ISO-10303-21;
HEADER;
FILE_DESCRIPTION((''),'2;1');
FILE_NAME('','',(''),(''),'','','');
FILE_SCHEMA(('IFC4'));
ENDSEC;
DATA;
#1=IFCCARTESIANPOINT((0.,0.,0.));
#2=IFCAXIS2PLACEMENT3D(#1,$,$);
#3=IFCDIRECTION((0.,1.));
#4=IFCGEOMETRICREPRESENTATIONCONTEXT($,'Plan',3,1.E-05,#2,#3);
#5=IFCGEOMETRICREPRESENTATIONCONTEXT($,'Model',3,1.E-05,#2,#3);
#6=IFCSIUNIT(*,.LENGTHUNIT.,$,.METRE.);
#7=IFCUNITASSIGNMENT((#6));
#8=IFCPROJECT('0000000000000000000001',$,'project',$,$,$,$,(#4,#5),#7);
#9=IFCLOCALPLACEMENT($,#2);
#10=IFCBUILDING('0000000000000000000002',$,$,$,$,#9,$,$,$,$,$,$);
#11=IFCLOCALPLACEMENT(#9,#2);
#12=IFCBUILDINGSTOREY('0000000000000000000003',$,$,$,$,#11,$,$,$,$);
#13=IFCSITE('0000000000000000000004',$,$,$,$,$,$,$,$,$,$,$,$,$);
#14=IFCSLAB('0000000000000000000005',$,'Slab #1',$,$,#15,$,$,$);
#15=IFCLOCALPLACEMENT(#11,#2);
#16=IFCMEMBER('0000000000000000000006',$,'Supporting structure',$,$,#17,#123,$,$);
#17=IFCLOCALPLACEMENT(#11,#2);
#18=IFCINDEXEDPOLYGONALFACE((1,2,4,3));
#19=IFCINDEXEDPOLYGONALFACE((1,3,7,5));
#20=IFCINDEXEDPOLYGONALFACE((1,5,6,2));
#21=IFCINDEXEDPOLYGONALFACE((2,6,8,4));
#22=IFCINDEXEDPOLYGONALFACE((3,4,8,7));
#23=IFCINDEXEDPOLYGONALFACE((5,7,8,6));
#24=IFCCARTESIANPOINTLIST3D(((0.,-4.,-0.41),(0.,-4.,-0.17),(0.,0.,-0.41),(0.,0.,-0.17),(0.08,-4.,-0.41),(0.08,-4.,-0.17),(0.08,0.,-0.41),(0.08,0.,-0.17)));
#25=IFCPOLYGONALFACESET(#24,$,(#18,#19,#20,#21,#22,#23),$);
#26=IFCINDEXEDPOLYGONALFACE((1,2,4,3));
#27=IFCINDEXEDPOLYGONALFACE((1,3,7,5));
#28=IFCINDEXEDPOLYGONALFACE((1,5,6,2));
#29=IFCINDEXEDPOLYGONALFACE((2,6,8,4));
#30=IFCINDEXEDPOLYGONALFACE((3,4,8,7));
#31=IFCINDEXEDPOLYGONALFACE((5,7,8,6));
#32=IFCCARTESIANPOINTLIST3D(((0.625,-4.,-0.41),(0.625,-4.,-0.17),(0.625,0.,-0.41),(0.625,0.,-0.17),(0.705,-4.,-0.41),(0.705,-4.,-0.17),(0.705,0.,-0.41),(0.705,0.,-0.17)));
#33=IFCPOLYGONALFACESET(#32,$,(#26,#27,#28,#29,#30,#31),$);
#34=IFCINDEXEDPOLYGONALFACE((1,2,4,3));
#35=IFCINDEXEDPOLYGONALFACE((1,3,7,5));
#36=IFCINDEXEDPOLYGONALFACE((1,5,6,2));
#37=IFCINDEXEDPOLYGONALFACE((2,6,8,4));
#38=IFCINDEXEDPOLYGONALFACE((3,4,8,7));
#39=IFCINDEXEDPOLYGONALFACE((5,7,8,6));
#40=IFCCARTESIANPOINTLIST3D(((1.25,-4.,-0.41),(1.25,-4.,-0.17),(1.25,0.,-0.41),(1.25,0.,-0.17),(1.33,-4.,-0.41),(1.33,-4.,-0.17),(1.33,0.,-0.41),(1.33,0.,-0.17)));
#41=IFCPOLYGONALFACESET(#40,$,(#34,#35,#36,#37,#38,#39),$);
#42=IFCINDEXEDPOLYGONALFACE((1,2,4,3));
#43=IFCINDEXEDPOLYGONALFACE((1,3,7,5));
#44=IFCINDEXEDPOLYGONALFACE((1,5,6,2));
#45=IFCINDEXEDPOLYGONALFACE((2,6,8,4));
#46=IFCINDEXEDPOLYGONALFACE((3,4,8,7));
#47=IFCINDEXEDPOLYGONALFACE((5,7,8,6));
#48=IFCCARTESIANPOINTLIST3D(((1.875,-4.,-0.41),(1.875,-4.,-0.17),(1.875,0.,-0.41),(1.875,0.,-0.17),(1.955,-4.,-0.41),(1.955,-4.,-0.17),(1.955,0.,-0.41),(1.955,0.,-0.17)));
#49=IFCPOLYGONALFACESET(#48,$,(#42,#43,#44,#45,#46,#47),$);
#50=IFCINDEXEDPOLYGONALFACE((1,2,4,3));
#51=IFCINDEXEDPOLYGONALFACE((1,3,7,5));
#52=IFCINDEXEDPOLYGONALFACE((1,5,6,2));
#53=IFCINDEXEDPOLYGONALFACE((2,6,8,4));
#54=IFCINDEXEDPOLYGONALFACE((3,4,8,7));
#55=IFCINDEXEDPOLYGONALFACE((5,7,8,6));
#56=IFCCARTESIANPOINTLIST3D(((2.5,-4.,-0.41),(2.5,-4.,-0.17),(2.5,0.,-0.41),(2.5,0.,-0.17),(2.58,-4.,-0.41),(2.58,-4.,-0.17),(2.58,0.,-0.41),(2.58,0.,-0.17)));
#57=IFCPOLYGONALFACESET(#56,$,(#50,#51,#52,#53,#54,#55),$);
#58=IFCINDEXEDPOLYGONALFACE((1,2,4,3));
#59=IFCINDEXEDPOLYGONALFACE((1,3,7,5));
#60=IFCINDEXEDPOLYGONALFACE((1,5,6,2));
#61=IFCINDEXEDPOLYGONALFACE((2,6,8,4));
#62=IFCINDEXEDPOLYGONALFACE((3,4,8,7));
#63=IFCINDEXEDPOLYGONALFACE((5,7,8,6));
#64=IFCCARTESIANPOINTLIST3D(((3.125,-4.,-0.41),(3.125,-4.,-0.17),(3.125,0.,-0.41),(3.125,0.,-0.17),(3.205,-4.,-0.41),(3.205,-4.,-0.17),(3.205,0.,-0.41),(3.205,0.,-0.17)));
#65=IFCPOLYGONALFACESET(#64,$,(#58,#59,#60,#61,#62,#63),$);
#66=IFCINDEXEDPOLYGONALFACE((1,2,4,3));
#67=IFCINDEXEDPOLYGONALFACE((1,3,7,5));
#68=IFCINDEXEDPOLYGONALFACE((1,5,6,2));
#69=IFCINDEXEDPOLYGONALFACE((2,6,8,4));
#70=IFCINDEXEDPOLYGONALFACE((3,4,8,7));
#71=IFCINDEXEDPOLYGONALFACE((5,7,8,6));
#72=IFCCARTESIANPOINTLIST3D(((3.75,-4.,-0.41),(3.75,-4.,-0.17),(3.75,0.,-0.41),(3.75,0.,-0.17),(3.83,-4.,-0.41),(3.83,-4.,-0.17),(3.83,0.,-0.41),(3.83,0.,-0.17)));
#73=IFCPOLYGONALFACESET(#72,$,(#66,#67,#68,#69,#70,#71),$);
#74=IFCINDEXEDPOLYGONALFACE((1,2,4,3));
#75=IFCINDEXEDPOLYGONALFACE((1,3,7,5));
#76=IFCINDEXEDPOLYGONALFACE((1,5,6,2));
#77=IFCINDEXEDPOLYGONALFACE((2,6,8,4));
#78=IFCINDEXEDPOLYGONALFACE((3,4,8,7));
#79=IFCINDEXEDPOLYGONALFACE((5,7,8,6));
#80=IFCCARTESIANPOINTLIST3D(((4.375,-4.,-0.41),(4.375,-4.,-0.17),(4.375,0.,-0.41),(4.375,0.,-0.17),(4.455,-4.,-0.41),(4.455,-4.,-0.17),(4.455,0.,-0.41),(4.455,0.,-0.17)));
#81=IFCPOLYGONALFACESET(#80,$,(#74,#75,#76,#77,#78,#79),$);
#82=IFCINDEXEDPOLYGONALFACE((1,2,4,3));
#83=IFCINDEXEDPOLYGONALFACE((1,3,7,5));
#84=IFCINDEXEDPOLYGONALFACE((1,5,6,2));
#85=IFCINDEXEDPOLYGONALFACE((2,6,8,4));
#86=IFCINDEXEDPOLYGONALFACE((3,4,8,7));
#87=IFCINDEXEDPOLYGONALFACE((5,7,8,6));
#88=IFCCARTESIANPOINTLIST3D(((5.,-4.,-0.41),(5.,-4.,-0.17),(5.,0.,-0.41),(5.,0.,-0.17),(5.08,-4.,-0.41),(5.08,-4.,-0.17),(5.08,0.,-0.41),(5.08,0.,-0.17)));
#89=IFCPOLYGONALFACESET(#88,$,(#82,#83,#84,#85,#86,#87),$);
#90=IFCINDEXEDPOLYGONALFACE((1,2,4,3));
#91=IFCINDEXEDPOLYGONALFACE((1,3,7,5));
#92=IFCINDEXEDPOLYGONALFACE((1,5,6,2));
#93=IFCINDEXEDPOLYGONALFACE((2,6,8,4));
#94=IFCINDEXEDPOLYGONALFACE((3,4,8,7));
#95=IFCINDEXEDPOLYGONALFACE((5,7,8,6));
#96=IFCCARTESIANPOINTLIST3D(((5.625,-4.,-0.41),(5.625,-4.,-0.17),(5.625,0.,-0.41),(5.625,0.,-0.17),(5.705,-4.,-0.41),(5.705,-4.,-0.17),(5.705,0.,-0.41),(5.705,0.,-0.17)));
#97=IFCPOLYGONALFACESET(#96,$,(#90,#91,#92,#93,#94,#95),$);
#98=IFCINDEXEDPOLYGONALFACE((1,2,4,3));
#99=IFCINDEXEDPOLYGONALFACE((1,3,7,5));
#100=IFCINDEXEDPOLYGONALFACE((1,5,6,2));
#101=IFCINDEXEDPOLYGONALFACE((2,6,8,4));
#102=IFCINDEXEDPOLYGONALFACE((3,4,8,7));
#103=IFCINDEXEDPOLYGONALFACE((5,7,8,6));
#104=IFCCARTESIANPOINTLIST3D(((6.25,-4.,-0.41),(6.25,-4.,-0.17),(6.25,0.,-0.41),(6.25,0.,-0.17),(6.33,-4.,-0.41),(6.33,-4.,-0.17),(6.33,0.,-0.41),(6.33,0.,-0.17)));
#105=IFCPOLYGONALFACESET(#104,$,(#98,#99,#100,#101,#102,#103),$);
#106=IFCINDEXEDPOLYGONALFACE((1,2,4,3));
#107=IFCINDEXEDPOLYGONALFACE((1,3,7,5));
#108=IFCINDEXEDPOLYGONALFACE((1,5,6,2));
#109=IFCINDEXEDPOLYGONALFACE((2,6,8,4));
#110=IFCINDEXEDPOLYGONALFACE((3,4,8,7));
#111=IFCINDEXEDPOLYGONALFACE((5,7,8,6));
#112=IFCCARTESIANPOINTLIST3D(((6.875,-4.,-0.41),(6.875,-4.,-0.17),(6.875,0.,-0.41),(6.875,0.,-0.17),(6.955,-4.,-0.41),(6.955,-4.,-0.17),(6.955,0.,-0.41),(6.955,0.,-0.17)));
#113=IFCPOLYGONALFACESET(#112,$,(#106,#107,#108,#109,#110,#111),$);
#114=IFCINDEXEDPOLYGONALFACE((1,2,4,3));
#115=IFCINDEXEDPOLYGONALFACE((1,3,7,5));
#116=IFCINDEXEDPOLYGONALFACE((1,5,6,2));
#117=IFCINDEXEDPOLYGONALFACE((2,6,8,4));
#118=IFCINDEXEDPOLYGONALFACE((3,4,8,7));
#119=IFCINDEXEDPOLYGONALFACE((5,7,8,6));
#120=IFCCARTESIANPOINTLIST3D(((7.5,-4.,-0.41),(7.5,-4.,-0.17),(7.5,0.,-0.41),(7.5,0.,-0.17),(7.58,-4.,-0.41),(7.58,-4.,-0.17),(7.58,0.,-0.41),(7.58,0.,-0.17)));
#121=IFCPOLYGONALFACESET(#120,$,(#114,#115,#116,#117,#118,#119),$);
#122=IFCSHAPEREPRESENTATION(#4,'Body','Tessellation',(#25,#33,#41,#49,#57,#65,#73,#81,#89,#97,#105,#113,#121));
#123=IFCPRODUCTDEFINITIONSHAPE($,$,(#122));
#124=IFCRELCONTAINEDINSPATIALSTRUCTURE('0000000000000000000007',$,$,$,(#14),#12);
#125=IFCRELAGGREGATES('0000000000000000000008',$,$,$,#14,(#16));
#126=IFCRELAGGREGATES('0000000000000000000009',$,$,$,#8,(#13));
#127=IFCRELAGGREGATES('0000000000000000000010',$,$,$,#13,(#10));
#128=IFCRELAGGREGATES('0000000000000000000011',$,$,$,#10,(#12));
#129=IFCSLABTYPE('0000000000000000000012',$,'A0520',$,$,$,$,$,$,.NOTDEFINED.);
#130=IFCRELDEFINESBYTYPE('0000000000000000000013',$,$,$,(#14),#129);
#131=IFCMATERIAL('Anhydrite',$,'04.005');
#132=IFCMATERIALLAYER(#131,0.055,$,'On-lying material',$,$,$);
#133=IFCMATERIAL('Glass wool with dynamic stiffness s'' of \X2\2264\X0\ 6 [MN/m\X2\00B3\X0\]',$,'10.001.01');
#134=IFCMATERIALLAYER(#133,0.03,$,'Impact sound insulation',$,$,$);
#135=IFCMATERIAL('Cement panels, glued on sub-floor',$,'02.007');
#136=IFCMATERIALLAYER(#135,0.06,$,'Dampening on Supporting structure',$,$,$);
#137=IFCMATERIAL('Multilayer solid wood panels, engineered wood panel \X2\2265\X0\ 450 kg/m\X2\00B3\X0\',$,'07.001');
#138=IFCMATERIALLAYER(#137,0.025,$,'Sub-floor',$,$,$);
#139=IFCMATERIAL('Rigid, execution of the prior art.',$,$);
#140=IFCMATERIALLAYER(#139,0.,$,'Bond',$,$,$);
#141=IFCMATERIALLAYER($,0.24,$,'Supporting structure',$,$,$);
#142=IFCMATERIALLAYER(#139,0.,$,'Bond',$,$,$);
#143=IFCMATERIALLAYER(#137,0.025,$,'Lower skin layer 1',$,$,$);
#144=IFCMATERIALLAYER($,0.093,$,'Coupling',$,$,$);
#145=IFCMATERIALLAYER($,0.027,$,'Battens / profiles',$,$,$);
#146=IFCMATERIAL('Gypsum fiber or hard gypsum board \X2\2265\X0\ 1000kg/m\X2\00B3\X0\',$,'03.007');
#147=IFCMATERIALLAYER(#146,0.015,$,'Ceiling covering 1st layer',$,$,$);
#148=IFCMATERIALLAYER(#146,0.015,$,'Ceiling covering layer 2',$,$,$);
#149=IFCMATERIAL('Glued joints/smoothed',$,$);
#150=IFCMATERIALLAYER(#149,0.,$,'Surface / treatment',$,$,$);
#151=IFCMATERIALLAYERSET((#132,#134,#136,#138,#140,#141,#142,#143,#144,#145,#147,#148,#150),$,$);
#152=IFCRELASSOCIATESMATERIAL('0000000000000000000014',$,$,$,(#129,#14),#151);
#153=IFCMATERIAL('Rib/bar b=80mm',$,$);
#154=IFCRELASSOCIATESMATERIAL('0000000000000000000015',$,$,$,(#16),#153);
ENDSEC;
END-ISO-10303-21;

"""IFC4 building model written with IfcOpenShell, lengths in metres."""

from ifc_helpers import new_model, si_unit, direction, frame, frame_2d, origin, place, context, project, spatial, rectangle, extrude, material, layer, layer_set, type_object, element, aggregate, save


model = new_model("IFC4")

# Units and contexts
plan_context = context("Plan", 3, precision=1e-05, world=origin(), true_north=direction((0.0, 1.0)))
model_context = context("Model", 3, precision=1e-05, world=origin(), true_north=direction((0.0, 1.0)))
ifc_project = project(units=[si_unit("LENGTHUNIT", "METRE")], contexts=[plan_context, model_context])

# Site, building, storey
site = spatial("IfcSite", under=ifc_project)
building_placement = place(None, origin())
building = spatial("IfcBuilding", under=site, at=building_placement)
storey_placement = place(building_placement, origin())
storey = spatial("IfcBuildingStorey", under=building, at=storey_placement)

# Slab, member
ifc_material_1 = material(Name="Anhydrite", Category="04.005")
ifc_layer_1 = layer(ifc_material_1, 0.055, Name="On-lying material")
ifc_material_2 = material(Name="Glass wool with dynamic stiffness s' of ≤ 6 [MN/m³]", Category="10.001.01")
ifc_layer_2 = layer(ifc_material_2, 0.03, Name="Impact sound insulation")
ifc_material_3 = material(Name="Cement panels, glued on sub-floor", Category="02.007")
ifc_layer_3 = layer(ifc_material_3, 0.06, Name="Dampening on Supporting structure")
ifc_material_4 = material(Name="Multilayer solid wood panels, engineered wood panel ≥ 450 kg/m³", Category="07.001")
ifc_layer_4 = layer(ifc_material_4, 0.025, Name="Sub-floor")
ifc_material_5 = material(Name="Rigid, execution of the prior art.")
ifc_layer_5 = layer(ifc_material_5, 0.0, Name="Bond")
ifc_layer_6 = layer(None, 0.24, Name="Supporting structure")
ifc_layer_7 = layer(ifc_material_5, 0.0, Name="Bond")
ifc_layer_8 = layer(ifc_material_4, 0.025, Name="Lower skin layer 1")
ifc_layer_9 = layer(None, 0.093, Name="Coupling")
ifc_layer_10 = layer(None, 0.027, Name="Battens / profiles")
ifc_material_6 = material(Name="Gypsum fiber or hard gypsum board ≥ 1000kg/m³", Category="03.007")
ifc_layer_11 = layer(ifc_material_6, 0.015, Name="Ceiling covering 1st layer")
ifc_layer_12 = layer(ifc_material_6, 0.015, Name="Ceiling covering layer 2")
ifc_material_7 = material(Name="Glued joints/smoothed")
ifc_layer_13 = layer(ifc_material_7, 0.0, Name="Surface / treatment")
ifc_layer_set = layer_set([ifc_layer_1, ifc_layer_2, ifc_layer_3, ifc_layer_4, ifc_layer_5, ifc_layer_6, ifc_layer_7, ifc_layer_8, ifc_layer_9, ifc_layer_10, ifc_layer_11, ifc_layer_12, ifc_layer_13])
slab_type = type_object("IfcSlabType", Name="A0520", PredefinedType="NOTDEFINED", material=ifc_layer_set)
slab_placement = place(None, frame((0.0, 0.0, 0.0), z_axis=(0.0, 0.0, -1.0), x_axis=(1.0, 0.0, 0.0)))
slab = element("IfcSlab", 1, at=slab_placement, inside=storey, type_object=slab_type, material=ifc_layer_set, Name="Slab #1")
ifc_material_8 = material(Name="Rib/bar b=80mm")
member_1_placement = place(slab_placement, origin())
member_1 = element("IfcMember", 2, at=member_1_placement, material=ifc_material_8, Name="Supporting structure", context=plan_context, shape_type="SweptSolid", body=[
    extrude(rectangle(XDim=0.08, YDim=0.24, at=frame_2d((0.04, 0.12), x_axis=(1.0, 0.0))), frame((0.0, 4.0, 0.17), z_axis=(0.0, -1.0, 0.0), x_axis=(1.0, 0.0, 0.0)), (0.0, 0.0, 1.0), 4.0),
    extrude(rectangle(XDim=0.08, YDim=0.24, at=frame_2d((0.04, 0.12), x_axis=(1.0, 0.0))), frame((0.625, 4.0, 0.17), z_axis=(0.0, -1.0, 0.0), x_axis=(1.0, 0.0, 0.0)), (0.0, 0.0, 1.0), 4.0),
    extrude(rectangle(XDim=0.08, YDim=0.24, at=frame_2d((0.04, 0.12), x_axis=(1.0, 0.0))), frame((1.25, 4.0, 0.17), z_axis=(0.0, -1.0, 0.0), x_axis=(1.0, 0.0, 0.0)), (0.0, 0.0, 1.0), 4.0),
    extrude(rectangle(XDim=0.08, YDim=0.24, at=frame_2d((0.04, 0.12), x_axis=(1.0, 0.0))), frame((1.875, 4.0, 0.17), z_axis=(0.0, -1.0, 0.0), x_axis=(1.0, 0.0, 0.0)), (0.0, 0.0, 1.0), 4.0),
    extrude(rectangle(XDim=0.08, YDim=0.24, at=frame_2d((0.04, 0.12), x_axis=(1.0, 0.0))), frame((2.5, 4.0, 0.17), z_axis=(0.0, -1.0, 0.0), x_axis=(1.0, 0.0, 0.0)), (0.0, 0.0, 1.0), 4.0),
    extrude(rectangle(XDim=0.08, YDim=0.24, at=frame_2d((0.04, 0.12), x_axis=(1.0, 0.0))), frame((3.125, 4.0, 0.17), z_axis=(0.0, -1.0, 0.0), x_axis=(1.0, 0.0, 0.0)), (0.0, 0.0, 1.0), 4.0),
    extrude(rectangle(XDim=0.08, YDim=0.24, at=frame_2d((0.04, 0.12), x_axis=(1.0, 0.0))), frame((3.75, 4.0, 0.17), z_axis=(0.0, -1.0, 0.0), x_axis=(1.0, 0.0, 0.0)), (0.0, 0.0, 1.0), 4.0),
    extrude(rectangle(XDim=0.08, YDim=0.24, at=frame_2d((0.04, 0.12), x_axis=(1.0, 0.0))), frame((4.375, 4.0, 0.17), z_axis=(0.0, -1.0, 0.0), x_axis=(1.0, 0.0, 0.0)), (0.0, 0.0, 1.0), 4.0),
    extrude(rectangle(XDim=0.08, YDim=0.24, at=frame_2d((0.04, 0.12), x_axis=(1.0, 0.0))), frame((5.0, 4.0, 0.17), z_axis=(0.0, -1.0, 0.0), x_axis=(1.0, 0.0, 0.0)), (0.0, 0.0, 1.0), 4.0),
    extrude(rectangle(XDim=0.08, YDim=0.24, at=frame_2d((0.04, 0.12), x_axis=(1.0, 0.0))), frame((5.625, 4.0, 0.17), z_axis=(0.0, -1.0, 0.0), x_axis=(1.0, 0.0, 0.0)), (0.0, 0.0, 1.0), 4.0),
    extrude(rectangle(XDim=0.08, YDim=0.24, at=frame_2d((0.04, 0.12), x_axis=(1.0, 0.0))), frame((6.25, 4.0, 0.17), z_axis=(0.0, -1.0, 0.0), x_axis=(1.0, 0.0, 0.0)), (0.0, 0.0, 1.0), 4.0),
    extrude(rectangle(XDim=0.08, YDim=0.24, at=frame_2d((0.04, 0.12), x_axis=(1.0, 0.0))), frame((6.875, 4.0, 0.17), z_axis=(0.0, -1.0, 0.0), x_axis=(1.0, 0.0, 0.0)), (0.0, 0.0, 1.0), 4.0),
    extrude(rectangle(XDim=0.08, YDim=0.24, at=frame_2d((0.04, 0.12), x_axis=(1.0, 0.0))), frame((7.5, 4.0, 0.17), z_axis=(0.0, -1.0, 0.0), x_axis=(1.0, 0.0, 0.0)), (0.0, 0.0, 1.0), 4.0),
])
aggregate(slab, [member_1])

save(model, "model.ifc")
